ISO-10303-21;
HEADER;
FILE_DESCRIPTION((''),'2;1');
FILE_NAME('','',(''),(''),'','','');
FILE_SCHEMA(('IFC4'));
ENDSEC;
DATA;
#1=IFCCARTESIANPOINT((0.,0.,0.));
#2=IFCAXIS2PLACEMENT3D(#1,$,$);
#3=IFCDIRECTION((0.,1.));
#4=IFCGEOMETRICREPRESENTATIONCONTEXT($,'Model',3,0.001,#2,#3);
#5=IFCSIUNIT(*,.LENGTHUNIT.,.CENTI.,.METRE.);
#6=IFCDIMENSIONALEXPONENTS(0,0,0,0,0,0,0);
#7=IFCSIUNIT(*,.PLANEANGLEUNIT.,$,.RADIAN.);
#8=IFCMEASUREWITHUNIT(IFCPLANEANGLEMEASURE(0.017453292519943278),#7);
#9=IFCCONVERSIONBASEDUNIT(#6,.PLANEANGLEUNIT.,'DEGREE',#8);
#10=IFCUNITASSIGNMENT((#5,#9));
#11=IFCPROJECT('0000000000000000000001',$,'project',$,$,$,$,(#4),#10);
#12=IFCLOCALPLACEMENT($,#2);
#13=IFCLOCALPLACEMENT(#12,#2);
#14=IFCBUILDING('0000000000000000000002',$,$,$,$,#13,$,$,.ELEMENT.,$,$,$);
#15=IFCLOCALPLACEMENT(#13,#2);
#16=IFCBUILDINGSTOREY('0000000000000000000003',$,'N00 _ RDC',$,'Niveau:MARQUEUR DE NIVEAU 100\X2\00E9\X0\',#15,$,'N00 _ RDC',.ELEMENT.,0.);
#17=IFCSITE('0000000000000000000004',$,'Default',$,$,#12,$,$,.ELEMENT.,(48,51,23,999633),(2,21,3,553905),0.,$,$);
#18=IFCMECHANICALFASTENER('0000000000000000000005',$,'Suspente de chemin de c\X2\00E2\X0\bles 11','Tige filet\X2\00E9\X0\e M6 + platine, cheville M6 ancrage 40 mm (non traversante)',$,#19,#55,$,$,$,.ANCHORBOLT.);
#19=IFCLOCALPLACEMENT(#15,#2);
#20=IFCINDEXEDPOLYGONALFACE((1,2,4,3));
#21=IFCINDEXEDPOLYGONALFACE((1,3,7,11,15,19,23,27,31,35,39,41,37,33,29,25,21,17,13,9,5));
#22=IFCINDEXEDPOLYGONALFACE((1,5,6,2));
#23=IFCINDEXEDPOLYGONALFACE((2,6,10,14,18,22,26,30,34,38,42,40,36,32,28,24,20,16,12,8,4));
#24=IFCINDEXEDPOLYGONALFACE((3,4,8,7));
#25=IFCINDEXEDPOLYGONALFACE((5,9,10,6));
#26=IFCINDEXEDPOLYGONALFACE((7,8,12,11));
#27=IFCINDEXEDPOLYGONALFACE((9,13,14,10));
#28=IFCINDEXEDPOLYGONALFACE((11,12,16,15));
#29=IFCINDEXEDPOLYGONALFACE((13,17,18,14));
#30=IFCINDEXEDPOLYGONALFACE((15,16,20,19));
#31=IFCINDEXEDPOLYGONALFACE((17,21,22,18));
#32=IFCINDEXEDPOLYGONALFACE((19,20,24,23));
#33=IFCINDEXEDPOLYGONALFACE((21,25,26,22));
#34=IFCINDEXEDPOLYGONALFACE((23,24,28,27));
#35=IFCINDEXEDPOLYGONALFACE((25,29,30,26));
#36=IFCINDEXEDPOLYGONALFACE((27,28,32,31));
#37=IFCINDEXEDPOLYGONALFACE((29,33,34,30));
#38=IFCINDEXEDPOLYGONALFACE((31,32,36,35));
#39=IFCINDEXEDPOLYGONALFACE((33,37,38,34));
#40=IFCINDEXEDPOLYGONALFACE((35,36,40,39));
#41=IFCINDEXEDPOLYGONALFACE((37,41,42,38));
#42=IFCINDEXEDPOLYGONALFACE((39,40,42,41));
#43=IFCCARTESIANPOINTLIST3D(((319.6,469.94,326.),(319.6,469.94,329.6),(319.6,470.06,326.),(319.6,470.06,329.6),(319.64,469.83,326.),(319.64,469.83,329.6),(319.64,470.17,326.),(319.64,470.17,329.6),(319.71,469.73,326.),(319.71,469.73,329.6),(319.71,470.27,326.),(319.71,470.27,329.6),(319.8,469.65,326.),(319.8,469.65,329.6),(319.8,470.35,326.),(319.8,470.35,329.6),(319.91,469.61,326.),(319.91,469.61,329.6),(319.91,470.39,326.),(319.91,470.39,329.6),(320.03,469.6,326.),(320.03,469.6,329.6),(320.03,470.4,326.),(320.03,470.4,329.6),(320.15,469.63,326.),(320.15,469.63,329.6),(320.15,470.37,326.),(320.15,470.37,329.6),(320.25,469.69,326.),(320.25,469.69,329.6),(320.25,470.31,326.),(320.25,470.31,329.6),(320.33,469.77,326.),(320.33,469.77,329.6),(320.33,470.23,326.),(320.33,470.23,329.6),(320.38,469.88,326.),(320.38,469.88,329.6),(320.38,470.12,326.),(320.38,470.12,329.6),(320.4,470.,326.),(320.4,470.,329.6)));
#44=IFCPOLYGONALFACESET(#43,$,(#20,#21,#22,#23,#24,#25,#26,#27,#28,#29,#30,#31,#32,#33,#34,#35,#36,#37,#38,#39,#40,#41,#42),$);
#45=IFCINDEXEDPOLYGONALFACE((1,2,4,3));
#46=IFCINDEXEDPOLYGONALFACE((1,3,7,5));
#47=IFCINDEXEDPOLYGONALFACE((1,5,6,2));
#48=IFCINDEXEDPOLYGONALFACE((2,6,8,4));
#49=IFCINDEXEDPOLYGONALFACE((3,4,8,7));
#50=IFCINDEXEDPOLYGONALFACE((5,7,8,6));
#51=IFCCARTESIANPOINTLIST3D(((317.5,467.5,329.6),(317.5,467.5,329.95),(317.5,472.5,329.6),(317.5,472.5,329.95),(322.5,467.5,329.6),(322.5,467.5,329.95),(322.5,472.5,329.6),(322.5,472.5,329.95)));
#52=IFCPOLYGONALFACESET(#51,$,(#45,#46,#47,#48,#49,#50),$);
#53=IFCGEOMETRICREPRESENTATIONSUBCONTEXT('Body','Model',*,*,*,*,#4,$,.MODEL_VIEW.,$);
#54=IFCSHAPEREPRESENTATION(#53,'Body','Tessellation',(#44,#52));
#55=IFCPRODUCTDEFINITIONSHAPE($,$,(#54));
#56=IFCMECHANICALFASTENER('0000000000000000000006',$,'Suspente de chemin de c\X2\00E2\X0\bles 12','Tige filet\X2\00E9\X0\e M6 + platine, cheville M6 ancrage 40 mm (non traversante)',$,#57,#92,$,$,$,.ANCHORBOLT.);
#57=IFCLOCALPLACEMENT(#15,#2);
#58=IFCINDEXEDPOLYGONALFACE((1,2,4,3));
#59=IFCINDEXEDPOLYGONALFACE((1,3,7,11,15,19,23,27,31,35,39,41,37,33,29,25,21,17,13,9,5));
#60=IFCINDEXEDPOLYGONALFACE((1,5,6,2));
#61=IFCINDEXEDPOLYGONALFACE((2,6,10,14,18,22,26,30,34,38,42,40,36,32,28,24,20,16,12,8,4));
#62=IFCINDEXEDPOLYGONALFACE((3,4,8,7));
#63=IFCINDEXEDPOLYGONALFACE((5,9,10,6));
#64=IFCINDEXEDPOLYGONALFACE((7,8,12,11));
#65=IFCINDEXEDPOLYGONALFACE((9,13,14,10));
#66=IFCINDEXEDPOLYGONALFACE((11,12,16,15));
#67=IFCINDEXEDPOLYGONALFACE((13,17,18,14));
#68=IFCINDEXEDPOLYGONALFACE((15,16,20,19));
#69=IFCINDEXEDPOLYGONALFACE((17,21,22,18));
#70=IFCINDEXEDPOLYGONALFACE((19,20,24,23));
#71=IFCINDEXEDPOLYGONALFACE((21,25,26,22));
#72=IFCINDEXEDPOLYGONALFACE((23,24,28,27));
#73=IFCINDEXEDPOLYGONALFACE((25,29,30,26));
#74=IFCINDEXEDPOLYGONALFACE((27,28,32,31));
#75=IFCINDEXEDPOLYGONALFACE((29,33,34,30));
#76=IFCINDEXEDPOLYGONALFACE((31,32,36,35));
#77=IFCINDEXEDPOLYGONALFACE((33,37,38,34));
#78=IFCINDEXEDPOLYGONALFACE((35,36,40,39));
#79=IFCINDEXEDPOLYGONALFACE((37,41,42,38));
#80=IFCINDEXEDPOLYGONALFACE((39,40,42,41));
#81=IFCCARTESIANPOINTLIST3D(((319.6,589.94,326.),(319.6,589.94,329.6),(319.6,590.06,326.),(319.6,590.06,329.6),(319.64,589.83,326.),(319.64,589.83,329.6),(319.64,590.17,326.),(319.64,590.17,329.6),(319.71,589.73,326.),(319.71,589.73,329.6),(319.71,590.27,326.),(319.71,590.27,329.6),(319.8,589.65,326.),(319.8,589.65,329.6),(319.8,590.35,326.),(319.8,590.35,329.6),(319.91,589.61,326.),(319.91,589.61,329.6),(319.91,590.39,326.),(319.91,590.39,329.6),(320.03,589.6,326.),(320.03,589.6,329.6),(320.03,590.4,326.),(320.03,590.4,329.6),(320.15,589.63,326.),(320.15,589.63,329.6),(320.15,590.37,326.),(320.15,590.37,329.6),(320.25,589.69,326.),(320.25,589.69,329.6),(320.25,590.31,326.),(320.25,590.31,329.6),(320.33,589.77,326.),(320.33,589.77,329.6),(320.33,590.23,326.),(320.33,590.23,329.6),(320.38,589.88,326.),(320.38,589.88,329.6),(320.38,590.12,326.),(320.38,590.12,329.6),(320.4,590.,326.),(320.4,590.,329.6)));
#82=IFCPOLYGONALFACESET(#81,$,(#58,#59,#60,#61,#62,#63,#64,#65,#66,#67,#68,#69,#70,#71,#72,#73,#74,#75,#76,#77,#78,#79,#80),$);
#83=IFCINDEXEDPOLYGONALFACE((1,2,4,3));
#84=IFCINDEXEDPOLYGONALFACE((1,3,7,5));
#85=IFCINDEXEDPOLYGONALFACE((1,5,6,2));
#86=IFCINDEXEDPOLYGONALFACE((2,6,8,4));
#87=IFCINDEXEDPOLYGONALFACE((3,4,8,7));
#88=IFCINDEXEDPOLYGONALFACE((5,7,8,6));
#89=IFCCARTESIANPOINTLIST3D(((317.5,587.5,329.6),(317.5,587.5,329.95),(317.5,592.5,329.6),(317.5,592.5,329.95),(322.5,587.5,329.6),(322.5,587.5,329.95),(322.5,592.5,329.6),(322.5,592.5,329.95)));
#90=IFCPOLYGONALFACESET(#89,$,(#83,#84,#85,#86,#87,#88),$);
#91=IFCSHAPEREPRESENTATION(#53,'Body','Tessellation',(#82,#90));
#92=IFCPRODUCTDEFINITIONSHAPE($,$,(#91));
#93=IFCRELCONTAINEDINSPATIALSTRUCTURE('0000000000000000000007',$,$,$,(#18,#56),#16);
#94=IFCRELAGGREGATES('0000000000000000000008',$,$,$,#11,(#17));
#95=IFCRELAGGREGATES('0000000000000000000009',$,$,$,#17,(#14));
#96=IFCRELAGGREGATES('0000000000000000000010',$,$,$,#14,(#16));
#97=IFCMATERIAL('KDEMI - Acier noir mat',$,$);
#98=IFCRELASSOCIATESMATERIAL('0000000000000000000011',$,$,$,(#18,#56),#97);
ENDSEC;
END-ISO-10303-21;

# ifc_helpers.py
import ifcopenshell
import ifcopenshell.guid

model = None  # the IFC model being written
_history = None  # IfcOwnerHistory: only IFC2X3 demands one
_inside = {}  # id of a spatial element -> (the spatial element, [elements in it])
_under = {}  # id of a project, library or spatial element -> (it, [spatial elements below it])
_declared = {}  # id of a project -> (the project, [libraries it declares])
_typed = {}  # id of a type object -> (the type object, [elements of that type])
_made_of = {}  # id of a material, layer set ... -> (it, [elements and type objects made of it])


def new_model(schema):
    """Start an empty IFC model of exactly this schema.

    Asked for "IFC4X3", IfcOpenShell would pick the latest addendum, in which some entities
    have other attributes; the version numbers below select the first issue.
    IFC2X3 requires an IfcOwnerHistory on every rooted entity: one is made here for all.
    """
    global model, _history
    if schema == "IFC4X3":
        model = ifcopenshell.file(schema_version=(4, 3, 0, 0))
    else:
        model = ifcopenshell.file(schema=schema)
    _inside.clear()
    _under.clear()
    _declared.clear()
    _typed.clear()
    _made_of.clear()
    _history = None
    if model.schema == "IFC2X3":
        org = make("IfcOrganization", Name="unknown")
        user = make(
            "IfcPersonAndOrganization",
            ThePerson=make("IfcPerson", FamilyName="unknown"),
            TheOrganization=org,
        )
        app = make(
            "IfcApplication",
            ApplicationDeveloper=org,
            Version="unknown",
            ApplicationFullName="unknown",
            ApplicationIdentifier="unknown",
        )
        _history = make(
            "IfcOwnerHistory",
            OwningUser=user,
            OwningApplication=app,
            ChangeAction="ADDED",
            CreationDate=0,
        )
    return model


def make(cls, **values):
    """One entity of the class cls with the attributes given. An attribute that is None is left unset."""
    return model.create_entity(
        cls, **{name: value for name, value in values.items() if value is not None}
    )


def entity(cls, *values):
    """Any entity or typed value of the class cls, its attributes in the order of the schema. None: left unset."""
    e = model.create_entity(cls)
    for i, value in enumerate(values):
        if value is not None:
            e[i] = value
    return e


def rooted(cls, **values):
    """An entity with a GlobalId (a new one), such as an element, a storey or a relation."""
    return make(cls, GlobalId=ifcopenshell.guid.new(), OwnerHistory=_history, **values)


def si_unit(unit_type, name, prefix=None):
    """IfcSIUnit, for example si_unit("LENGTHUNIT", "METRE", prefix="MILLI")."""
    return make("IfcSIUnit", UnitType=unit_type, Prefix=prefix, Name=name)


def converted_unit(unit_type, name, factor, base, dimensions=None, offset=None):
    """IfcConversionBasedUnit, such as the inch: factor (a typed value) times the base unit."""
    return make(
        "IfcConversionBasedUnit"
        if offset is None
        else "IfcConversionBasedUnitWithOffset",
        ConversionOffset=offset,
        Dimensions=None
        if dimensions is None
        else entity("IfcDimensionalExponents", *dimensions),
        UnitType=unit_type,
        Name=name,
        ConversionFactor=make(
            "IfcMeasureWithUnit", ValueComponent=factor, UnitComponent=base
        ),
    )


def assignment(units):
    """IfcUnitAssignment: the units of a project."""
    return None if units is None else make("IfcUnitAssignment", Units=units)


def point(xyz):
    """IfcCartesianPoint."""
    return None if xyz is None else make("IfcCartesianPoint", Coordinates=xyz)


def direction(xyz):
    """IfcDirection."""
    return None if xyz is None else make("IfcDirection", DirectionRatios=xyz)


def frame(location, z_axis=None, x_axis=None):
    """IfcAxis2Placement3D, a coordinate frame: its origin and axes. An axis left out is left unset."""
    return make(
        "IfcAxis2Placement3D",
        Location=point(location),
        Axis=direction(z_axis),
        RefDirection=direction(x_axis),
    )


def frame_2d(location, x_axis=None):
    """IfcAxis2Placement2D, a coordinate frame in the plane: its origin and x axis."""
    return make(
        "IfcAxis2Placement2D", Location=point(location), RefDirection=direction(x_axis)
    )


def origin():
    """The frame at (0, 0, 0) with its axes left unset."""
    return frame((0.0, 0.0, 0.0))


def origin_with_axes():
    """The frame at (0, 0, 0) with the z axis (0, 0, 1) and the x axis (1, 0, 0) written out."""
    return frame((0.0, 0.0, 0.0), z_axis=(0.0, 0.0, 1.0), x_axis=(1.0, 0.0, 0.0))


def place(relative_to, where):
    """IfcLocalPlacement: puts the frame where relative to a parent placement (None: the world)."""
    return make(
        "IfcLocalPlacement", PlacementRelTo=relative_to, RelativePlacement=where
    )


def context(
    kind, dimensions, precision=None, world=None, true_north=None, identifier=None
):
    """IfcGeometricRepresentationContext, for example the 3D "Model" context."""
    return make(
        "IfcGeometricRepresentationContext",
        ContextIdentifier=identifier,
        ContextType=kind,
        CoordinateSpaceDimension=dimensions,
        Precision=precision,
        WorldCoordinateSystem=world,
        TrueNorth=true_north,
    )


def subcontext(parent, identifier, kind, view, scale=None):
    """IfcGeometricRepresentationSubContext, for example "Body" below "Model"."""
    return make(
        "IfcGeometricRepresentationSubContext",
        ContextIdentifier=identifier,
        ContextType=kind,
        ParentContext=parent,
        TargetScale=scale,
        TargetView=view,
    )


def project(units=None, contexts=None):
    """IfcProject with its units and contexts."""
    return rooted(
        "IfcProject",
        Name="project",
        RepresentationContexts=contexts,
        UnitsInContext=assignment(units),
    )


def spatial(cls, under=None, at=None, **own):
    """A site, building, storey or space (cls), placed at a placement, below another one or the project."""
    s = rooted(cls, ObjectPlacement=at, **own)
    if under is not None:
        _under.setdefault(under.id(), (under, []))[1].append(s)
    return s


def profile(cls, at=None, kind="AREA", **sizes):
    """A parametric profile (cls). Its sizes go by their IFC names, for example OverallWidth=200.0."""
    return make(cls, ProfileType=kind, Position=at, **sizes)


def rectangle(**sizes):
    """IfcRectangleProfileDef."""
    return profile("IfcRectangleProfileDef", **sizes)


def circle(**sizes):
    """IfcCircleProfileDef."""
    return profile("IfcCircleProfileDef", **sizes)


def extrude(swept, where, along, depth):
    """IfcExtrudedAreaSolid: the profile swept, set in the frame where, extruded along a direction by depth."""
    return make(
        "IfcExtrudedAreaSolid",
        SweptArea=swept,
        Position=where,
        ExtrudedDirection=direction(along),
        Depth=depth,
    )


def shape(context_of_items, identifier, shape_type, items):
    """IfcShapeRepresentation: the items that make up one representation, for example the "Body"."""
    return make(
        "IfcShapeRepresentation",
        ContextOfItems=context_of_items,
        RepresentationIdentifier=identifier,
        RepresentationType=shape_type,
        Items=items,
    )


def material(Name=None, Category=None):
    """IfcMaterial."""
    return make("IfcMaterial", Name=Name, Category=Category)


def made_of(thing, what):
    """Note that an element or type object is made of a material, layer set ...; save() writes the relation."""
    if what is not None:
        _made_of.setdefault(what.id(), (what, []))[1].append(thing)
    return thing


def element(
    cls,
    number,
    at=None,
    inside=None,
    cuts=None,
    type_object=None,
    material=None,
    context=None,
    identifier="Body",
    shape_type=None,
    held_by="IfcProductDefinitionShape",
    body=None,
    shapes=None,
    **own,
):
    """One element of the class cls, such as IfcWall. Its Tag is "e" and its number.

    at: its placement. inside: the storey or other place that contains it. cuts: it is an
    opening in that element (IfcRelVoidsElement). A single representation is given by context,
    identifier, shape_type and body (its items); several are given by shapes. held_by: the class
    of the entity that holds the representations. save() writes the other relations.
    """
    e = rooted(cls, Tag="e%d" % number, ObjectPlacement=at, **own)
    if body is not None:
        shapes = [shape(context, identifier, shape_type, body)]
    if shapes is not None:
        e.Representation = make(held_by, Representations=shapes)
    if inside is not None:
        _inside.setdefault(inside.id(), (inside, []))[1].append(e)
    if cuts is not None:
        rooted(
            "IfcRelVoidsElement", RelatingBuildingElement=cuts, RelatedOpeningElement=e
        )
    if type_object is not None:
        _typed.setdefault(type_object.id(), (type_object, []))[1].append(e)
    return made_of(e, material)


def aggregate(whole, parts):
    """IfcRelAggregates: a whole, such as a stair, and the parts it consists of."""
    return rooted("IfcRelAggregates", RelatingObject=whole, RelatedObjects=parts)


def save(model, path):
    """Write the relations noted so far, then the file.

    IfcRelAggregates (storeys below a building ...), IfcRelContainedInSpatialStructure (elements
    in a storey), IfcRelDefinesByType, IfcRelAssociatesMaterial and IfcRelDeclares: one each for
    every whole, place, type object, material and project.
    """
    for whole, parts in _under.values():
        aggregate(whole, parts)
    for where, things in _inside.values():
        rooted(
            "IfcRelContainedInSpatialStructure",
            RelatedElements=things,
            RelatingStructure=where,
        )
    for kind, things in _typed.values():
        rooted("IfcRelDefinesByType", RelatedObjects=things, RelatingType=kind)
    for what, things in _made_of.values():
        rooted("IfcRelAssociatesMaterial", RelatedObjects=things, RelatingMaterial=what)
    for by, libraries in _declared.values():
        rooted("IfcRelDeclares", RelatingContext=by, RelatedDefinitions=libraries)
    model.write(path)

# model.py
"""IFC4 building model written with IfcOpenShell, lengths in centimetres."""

from ifc_helpers import new_model, entity, si_unit, converted_unit, direction, frame, frame_2d, origin, origin_with_axes, place, context, subcontext, project, spatial, rectangle, circle, extrude, material, element, save


model = new_model("IFC4")

# Units and contexts
model_context = context("Model", 3, precision=0.001, world=origin(), true_north=direction((0.0, 1.0)))
body_context = subcontext(model_context, "Body", "Model", "MODEL_VIEW")
ifc_project = project(units=[si_unit("LENGTHUNIT", "METRE", prefix="CENTI"), converted_unit("PLANEANGLEUNIT", "DEGREE", entity("IfcPlaneAngleMeasure", 0.017453292519943278), si_unit("PLANEANGLEUNIT", "RADIAN"), dimensions=[0, 0, 0, 0, 0, 0, 0])], contexts=[model_context])

# Site, building, storey
site_placement = place(None, origin())
site = spatial("IfcSite", under=ifc_project, at=site_placement, Name="Default", CompositionType="ELEMENT", RefLatitude=(48, 51, 23, 999633), RefLongitude=(2, 21, 3, 553905), RefElevation=0.0)
building_placement = place(site_placement, origin())
building = spatial("IfcBuilding", under=site, at=building_placement, CompositionType="ELEMENT")
storey_placement = place(building_placement, origin())
storey = spatial("IfcBuildingStorey", under=building, at=storey_placement, Name="N00 _ RDC", ObjectType="Niveau:MARQUEUR DE NIVEAU 100é", LongName="N00 _ RDC", CompositionType="ELEMENT", Elevation=0.0)

# Shared definitions
ifc_material_1 = material(Name="KDEMI - Acier noir mat")

# Mechanical fasteners
mechanical_fastener_1_placement = place(storey_placement, origin_with_axes())
element("IfcMechanicalFastener", 1, at=mechanical_fastener_1_placement, inside=storey, material=ifc_material_1, Name="Suspente de chemin de câbles 11", Description="Tige filetée M6 + platine, cheville M6 ancrage 40 mm (non traversante)", PredefinedType="ANCHORBOLT", context=body_context, shape_type="SweptSolid", body=[
    extrude(circle(Radius=0.4, at=frame_2d((320.0, 470.0))), frame((0.0, 0.0, 326.0)), (0.0, 0.0, 1.0), 3.6),
    extrude(rectangle(XDim=5.0, YDim=5.0, at=frame_2d((320.0, 470.0))), frame((0.0, 0.0, 329.6)), (0.0, 0.0, 1.0), 0.35),
])
mechanical_fastener_2_placement = place(storey_placement, origin_with_axes())
element("IfcMechanicalFastener", 2, at=mechanical_fastener_2_placement, inside=storey, material=ifc_material_1, Name="Suspente de chemin de câbles 12", Description="Tige filetée M6 + platine, cheville M6 ancrage 40 mm (non traversante)", PredefinedType="ANCHORBOLT", context=body_context, shape_type="SweptSolid", body=[
    extrude(circle(Radius=0.4, at=frame_2d((320.0, 590.0))), frame((0.0, 0.0, 326.0)), (0.0, 0.0, 1.0), 3.6),
    extrude(rectangle(XDim=5.0, YDim=5.0, at=frame_2d((320.0, 590.0))), frame((0.0, 0.0, 329.6)), (0.0, 0.0, 1.0), 0.35),
])

save(model, "model.ifc")
